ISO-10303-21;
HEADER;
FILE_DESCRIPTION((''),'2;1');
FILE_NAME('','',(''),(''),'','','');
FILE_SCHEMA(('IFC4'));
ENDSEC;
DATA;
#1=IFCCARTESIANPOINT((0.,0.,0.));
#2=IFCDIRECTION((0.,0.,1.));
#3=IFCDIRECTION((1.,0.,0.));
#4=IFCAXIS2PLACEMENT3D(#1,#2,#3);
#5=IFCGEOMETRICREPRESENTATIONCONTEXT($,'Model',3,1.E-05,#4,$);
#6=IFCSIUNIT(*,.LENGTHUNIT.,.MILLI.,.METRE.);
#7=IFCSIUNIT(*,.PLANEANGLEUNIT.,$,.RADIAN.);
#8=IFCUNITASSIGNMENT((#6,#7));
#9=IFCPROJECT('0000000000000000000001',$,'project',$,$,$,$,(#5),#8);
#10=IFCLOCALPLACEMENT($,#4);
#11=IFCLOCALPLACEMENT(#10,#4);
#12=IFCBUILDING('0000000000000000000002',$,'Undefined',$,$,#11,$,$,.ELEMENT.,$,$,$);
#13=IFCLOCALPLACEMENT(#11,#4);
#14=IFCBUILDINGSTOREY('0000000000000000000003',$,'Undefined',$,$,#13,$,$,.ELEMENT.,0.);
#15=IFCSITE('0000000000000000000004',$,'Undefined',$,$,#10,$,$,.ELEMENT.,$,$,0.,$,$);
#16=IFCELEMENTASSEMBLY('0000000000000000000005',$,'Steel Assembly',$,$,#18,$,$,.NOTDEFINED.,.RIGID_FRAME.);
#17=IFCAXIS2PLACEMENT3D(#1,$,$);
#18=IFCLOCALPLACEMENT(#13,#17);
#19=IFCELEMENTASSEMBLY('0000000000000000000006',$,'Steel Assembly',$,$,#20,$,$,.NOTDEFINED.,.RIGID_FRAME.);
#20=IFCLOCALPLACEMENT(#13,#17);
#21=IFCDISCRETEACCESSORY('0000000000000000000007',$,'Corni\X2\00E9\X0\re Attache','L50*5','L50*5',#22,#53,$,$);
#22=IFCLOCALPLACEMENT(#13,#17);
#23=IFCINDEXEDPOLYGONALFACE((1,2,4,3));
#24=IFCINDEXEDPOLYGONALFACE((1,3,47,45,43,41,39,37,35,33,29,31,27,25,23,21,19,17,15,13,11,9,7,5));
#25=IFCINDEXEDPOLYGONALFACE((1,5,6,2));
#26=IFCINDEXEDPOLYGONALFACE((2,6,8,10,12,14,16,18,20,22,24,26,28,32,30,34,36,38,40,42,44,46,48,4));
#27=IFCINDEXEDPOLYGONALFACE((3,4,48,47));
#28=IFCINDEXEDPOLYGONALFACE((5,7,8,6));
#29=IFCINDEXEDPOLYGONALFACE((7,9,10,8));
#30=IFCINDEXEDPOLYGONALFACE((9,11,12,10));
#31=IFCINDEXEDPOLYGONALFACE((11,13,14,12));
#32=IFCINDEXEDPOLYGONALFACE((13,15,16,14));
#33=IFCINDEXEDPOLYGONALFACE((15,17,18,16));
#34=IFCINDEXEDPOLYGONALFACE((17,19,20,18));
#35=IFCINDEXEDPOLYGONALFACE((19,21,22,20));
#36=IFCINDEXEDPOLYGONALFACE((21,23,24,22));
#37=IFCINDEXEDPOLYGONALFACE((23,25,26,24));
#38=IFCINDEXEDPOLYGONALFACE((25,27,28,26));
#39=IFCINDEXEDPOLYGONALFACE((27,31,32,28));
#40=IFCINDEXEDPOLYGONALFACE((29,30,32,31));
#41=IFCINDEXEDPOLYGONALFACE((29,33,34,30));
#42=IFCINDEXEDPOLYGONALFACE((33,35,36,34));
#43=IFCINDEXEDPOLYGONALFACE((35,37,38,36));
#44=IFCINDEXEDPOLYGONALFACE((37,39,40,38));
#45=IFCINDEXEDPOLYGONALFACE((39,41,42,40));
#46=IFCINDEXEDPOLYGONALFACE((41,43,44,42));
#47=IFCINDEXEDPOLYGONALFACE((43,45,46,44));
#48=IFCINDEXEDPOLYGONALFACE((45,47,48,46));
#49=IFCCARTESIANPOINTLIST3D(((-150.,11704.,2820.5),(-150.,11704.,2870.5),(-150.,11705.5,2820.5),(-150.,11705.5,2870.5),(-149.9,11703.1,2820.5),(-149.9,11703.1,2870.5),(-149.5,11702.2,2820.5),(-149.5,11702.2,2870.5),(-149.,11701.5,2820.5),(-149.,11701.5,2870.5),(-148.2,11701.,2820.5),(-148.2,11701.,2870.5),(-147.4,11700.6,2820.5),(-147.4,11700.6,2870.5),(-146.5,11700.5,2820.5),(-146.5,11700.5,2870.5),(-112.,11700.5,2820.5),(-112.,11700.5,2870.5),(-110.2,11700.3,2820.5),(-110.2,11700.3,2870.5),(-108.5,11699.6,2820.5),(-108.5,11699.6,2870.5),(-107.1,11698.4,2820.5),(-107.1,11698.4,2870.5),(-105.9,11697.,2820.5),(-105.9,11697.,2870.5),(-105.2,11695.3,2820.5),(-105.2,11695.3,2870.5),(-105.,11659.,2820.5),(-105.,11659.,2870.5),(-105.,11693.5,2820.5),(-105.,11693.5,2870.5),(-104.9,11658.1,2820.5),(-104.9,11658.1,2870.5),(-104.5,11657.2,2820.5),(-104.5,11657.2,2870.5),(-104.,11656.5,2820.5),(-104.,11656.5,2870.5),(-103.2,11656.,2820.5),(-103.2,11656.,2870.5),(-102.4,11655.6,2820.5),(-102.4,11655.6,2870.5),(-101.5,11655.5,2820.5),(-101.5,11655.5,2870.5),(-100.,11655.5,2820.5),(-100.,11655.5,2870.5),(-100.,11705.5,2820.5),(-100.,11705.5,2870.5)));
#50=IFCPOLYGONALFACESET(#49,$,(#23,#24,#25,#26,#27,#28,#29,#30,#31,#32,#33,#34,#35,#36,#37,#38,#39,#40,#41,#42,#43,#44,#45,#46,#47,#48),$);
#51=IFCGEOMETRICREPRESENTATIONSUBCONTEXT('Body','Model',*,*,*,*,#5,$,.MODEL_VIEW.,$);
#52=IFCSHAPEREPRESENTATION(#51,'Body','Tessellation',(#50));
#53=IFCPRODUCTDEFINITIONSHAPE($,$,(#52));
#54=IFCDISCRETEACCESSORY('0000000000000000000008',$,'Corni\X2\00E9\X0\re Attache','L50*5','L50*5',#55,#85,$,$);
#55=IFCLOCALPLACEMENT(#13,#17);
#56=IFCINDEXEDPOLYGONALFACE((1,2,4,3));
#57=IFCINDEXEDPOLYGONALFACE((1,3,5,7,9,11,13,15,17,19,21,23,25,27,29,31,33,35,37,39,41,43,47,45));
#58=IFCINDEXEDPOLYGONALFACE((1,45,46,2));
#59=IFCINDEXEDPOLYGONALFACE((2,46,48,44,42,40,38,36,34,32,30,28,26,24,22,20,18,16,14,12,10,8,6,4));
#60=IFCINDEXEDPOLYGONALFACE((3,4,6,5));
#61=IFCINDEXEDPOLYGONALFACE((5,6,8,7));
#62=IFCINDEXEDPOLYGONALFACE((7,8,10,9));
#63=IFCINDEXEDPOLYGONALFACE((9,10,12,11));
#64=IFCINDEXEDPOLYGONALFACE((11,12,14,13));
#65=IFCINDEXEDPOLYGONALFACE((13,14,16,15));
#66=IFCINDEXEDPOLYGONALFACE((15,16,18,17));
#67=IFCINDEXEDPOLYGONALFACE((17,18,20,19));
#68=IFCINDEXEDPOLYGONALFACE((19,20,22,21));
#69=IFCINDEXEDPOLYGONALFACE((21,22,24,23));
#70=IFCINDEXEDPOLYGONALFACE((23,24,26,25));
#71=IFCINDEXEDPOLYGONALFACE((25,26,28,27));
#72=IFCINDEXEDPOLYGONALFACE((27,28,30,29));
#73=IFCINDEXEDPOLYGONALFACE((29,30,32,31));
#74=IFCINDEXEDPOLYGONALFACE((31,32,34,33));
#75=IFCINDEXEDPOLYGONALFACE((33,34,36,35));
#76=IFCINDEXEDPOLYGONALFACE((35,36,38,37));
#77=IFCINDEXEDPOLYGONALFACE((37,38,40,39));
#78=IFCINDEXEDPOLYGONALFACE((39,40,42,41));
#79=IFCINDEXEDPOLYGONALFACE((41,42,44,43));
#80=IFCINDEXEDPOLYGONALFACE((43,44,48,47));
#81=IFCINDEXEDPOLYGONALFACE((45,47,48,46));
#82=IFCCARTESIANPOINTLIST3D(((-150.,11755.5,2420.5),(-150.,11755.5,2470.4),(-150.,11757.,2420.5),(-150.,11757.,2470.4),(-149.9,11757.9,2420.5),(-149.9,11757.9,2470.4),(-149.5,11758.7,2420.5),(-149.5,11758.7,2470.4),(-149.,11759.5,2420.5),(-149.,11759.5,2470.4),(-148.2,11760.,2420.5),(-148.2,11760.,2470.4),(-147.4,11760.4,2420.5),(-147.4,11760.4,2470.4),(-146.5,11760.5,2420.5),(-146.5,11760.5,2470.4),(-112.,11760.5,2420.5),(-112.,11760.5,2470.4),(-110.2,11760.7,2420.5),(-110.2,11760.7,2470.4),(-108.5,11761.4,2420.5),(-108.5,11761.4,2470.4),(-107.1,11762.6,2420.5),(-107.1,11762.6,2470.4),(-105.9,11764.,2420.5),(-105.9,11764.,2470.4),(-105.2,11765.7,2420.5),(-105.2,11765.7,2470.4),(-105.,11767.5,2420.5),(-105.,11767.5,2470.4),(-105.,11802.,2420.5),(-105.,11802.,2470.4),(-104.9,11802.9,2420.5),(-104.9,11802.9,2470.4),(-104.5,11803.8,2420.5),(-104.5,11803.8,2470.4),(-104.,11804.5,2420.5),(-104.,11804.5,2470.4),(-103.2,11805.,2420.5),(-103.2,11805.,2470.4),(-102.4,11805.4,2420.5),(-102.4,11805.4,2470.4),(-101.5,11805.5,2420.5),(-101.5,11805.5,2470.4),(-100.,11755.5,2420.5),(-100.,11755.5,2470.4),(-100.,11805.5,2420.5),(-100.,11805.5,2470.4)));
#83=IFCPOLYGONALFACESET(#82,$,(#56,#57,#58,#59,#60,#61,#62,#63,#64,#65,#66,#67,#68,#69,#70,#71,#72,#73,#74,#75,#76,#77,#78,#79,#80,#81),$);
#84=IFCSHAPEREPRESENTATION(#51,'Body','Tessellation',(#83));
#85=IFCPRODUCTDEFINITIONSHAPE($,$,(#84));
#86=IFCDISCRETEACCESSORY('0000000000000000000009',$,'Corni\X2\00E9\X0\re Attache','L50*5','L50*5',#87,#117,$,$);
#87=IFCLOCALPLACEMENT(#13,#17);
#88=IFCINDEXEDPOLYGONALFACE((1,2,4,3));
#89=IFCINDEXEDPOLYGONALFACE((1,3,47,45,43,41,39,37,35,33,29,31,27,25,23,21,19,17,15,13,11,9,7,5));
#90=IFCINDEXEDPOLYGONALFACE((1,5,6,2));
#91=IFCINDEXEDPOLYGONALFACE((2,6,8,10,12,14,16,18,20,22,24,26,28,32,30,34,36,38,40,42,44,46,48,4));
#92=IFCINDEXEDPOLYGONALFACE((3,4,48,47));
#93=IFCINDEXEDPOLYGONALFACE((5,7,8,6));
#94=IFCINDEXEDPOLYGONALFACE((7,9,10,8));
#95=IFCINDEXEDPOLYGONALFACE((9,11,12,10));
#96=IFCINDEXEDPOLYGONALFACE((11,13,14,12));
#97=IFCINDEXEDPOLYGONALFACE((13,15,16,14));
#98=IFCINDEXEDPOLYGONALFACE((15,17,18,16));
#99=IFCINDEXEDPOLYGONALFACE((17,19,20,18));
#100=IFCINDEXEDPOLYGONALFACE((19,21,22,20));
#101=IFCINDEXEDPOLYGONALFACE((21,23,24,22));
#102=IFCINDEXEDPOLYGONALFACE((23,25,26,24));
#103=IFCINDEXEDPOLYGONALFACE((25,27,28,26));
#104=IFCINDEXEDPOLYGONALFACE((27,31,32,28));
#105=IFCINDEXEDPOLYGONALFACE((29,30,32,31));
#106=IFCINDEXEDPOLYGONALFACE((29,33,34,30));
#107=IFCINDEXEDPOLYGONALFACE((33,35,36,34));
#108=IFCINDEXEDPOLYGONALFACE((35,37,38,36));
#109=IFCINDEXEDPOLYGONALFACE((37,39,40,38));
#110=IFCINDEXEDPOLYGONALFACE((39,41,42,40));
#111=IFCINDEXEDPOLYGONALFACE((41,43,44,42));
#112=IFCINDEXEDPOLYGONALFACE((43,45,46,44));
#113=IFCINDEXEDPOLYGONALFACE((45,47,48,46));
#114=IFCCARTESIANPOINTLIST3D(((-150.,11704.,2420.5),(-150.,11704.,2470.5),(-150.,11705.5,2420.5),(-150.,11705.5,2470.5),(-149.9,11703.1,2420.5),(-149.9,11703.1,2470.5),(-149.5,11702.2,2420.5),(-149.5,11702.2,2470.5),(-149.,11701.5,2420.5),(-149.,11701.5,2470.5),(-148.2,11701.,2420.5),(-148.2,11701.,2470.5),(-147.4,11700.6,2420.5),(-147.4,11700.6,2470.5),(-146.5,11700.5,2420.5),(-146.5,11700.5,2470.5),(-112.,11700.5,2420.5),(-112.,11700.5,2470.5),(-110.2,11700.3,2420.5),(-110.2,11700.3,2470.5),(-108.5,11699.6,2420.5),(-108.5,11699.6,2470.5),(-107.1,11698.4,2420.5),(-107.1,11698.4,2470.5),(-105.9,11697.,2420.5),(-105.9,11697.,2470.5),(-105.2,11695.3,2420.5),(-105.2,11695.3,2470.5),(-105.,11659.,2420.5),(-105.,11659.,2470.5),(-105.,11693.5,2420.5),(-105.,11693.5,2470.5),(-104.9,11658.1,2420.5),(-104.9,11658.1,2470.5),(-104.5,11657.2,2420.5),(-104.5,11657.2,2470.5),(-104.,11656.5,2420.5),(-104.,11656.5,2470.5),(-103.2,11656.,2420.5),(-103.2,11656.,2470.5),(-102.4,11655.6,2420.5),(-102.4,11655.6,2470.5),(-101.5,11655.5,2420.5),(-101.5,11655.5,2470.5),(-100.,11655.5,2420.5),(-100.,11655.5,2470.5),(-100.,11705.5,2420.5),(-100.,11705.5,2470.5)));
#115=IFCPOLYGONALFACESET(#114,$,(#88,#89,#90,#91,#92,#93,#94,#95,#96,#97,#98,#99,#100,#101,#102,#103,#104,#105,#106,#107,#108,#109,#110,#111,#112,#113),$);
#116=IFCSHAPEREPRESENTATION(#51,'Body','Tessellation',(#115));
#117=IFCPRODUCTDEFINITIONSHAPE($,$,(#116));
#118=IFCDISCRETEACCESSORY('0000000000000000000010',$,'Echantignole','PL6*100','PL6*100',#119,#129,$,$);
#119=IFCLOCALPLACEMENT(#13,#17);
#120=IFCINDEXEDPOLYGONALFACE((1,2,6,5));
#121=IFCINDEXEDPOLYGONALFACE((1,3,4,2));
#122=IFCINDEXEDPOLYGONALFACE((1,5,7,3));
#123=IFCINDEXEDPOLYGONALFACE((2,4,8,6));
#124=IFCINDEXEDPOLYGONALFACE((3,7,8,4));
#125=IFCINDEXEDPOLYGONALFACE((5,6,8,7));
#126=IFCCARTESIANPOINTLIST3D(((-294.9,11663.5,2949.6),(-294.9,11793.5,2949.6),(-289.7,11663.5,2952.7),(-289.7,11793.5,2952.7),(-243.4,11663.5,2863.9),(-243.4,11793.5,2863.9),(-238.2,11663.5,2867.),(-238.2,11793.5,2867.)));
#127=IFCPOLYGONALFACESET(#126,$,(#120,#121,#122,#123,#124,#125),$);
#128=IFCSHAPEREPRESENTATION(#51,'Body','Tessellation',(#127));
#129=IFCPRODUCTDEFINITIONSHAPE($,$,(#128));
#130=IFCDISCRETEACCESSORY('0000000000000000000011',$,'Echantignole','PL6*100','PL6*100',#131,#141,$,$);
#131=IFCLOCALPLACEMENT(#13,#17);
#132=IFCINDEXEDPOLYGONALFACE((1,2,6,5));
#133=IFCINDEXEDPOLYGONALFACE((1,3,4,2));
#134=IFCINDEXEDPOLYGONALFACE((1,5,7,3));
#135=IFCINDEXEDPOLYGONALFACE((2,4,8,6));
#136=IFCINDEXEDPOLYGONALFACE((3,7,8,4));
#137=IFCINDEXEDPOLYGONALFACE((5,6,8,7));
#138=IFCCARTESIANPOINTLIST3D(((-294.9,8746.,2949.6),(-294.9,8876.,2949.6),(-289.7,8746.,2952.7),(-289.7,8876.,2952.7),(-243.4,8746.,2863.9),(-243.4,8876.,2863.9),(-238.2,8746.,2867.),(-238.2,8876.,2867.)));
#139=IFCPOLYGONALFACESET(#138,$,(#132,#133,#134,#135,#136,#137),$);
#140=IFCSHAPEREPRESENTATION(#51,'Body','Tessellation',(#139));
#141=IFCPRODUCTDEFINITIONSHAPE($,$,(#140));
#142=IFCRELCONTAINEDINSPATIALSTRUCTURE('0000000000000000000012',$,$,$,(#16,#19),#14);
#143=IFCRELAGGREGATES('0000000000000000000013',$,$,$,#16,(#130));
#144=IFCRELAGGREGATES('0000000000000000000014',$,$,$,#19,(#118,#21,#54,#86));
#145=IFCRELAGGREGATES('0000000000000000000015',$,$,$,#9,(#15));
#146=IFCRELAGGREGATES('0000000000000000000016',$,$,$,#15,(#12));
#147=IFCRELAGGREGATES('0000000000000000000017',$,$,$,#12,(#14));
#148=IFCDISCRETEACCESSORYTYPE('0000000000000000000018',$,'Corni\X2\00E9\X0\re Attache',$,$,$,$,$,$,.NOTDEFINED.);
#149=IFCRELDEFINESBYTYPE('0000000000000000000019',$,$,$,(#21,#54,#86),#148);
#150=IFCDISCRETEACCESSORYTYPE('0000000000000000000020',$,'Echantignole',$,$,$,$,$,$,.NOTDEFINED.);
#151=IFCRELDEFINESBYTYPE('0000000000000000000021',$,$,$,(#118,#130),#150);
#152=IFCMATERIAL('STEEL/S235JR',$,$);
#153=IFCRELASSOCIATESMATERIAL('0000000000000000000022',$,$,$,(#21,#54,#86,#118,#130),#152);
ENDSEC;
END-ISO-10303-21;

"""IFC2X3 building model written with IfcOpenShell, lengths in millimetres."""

from ifc_helpers import new_model, si_unit, frame, origin_with_axes, origin_2d_with_axis, place, context, subcontext, project, spatial, polyline, l_section, outline, extrude, material, type_object, element, aggregate, save


model = new_model("IFC2X3")

# Units and contexts
model_context = context("Model", 3, precision=1e-05, world=origin_with_axes())
body_context = subcontext(model_context, "Body", "Model", "MODEL_VIEW")
ifc_project = project(units=[si_unit("LENGTHUNIT", "METRE", prefix="MILLI"), si_unit("PLANEANGLEUNIT", "RADIAN")], contexts=[model_context])

# Site, building, storey
site_placement = place(None, origin_with_axes())
site = spatial("IfcSite", under=ifc_project, at=site_placement, Name="Undefined", CompositionType="ELEMENT", RefElevation=0.0)
building_placement = place(site_placement, origin_with_axes())
building = spatial("IfcBuilding", under=site, at=building_placement, Name="Undefined", CompositionType="ELEMENT")
storey_placement = place(building_placement, origin_with_axes())
storey = spatial("IfcBuildingStorey", under=building, at=storey_placement, Name="Undefined", CompositionType="ELEMENT", Elevation=0.0)

# Element assemblies
assembly_1_placement = place(storey_placement, origin_with_axes())
assembly_1 = element("IfcElementAssembly", 1, at=assembly_1_placement, inside=storey, Name="Steel Assembly", AssemblyPlace="NOTDEFINED", PredefinedType="RIGID_FRAME")
ifc_material_1 = material(Name="STEEL/S235JR")
assembly_2_placement = place(storey_placement, origin_with_axes())
assembly_2 = element("IfcElementAssembly", 2, at=assembly_2_placement, inside=storey, Name="Steel Assembly", AssemblyPlace="NOTDEFINED", PredefinedType="RIGID_FRAME")

# Discrete accessories
discrete_accessory_type_1 = type_object("IfcDiscreteAccessoryType", Name="Corniére Attache")
discrete_accessory_1_placement = place(assembly_2_placement, frame((-125.0, 11680.5, 2820.5), z_axis=(0.0, 0.0, 1.0), x_axis=(1.0, 0.0, 0.0)))
discrete_accessory_1 = element("IfcDiscreteAccessory", 3, at=discrete_accessory_1_placement, type_object=discrete_accessory_type_1, material=ifc_material_1, Name="Corniére Attache", Description="L50*5", ObjectType="L50*5", context=body_context, shape_type="SweptSolid", body=[
    extrude(l_section(Depth=50.0, Width=50.0, Thickness=5.0, FilletRadius=7.0, EdgeRadius=3.5, at=origin_2d_with_axis()), frame((0.0, 0.0, 50.0), z_axis=(0.0, 0.0, -1.0), x_axis=(0.0, -1.0, 0.0)), (0.0, 0.0, 1.0), 50.0),
])
discrete_accessory_2_placement = place(assembly_2_placement, frame((-125.0, 11780.5, 2470.4), z_axis=(-1.0, 0.0, 0.0), x_axis=(0.0, 0.0, -1.0)))
discrete_accessory_2 = element("IfcDiscreteAccessory", 4, at=discrete_accessory_2_placement, type_object=discrete_accessory_type_1, material=ifc_material_1, Name="Corniére Attache", Description="L50*5", ObjectType="L50*5", context=body_context, shape_type="SweptSolid", body=[
    extrude(l_section(Depth=50.0, Width=50.0, Thickness=5.0, FilletRadius=7.0, EdgeRadius=3.5, at=origin_2d_with_axis()), frame((49.9, 0.0, 0.0), z_axis=(-1.0, 0.0, 0.0), x_axis=(0.0, -1.0, 0.0)), (0.0, 0.0, 1.0), 49.9),
])
discrete_accessory_3_placement = place(assembly_2_placement, frame((-125.0, 11680.5, 2420.5), z_axis=(0.0, 0.0, 1.0), x_axis=(1.0, 0.0, 0.0)))
discrete_accessory_3 = element("IfcDiscreteAccessory", 5, at=discrete_accessory_3_placement, type_object=discrete_accessory_type_1, material=ifc_material_1, Name="Corniére Attache", Description="L50*5", ObjectType="L50*5", context=body_context, shape_type="SweptSolid", body=[
    extrude(l_section(Depth=50.0, Width=50.0, Thickness=5.0, FilletRadius=7.0, EdgeRadius=3.5, at=origin_2d_with_axis()), frame((0.0, 0.0, 50.0), z_axis=(0.0, 0.0, -1.0), x_axis=(0.0, -1.0, 0.0)), (0.0, 0.0, 1.0), 50.0),
])
discrete_accessory_type_2 = type_object("IfcDiscreteAccessoryType", Name="Echantignole")
discrete_accessory_4_placement = place(assembly_2_placement, frame((-266.5, 11793.5, 2908.3), z_axis=(-0.857169, 0.0, -0.515036), x_axis=(0.0, -1.0, 0.0)))
discrete_accessory_4 = element("IfcDiscreteAccessory", 6, at=discrete_accessory_4_placement, type_object=discrete_accessory_type_2, material=ifc_material_1, Name="Echantignole", Description="PL6*100", ObjectType="PL6*100", context=body_context, shape_type="SweptSolid", body=[
    extrude(outline(polyline([(130.0, -50.0), (0.0, -50.0), (0.0, 50.0), (130.0, 50.0), (130.0, -50.0)])), frame((0.0, 0.0, -3.0), z_axis=(0.0, 0.0, 1.0), x_axis=(1.0, 0.0, 0.0)), (0.0, 0.0, 1.0), 6.0),
])
discrete_accessory_5_placement = place(assembly_1_placement, frame((-266.5, 8876.0, 2908.3), z_axis=(-0.857169, 0.0, -0.515036), x_axis=(0.0, -1.0, 0.0)))
discrete_accessory_5 = element("IfcDiscreteAccessory", 7, at=discrete_accessory_5_placement, type_object=discrete_accessory_type_2, material=ifc_material_1, Name="Echantignole", Description="PL6*100", ObjectType="PL6*100", context=body_context, shape_type="SweptSolid", body=[
    extrude(outline(polyline([(130.0, -50.0), (0.0, -50.0), (0.0, 50.0), (130.0, 50.0), (130.0, -50.0)])), frame((0.0, 0.0, -3.0), z_axis=(0.0, 0.0, 1.0), x_axis=(1.0, 0.0, 0.0)), (0.0, 0.0, 1.0), 6.0),
])

aggregate(assembly_1, [discrete_accessory_5])
aggregate(assembly_2, [discrete_accessory_4, discrete_accessory_1, discrete_accessory_2, discrete_accessory_3])

save(model, "model.ifc")
